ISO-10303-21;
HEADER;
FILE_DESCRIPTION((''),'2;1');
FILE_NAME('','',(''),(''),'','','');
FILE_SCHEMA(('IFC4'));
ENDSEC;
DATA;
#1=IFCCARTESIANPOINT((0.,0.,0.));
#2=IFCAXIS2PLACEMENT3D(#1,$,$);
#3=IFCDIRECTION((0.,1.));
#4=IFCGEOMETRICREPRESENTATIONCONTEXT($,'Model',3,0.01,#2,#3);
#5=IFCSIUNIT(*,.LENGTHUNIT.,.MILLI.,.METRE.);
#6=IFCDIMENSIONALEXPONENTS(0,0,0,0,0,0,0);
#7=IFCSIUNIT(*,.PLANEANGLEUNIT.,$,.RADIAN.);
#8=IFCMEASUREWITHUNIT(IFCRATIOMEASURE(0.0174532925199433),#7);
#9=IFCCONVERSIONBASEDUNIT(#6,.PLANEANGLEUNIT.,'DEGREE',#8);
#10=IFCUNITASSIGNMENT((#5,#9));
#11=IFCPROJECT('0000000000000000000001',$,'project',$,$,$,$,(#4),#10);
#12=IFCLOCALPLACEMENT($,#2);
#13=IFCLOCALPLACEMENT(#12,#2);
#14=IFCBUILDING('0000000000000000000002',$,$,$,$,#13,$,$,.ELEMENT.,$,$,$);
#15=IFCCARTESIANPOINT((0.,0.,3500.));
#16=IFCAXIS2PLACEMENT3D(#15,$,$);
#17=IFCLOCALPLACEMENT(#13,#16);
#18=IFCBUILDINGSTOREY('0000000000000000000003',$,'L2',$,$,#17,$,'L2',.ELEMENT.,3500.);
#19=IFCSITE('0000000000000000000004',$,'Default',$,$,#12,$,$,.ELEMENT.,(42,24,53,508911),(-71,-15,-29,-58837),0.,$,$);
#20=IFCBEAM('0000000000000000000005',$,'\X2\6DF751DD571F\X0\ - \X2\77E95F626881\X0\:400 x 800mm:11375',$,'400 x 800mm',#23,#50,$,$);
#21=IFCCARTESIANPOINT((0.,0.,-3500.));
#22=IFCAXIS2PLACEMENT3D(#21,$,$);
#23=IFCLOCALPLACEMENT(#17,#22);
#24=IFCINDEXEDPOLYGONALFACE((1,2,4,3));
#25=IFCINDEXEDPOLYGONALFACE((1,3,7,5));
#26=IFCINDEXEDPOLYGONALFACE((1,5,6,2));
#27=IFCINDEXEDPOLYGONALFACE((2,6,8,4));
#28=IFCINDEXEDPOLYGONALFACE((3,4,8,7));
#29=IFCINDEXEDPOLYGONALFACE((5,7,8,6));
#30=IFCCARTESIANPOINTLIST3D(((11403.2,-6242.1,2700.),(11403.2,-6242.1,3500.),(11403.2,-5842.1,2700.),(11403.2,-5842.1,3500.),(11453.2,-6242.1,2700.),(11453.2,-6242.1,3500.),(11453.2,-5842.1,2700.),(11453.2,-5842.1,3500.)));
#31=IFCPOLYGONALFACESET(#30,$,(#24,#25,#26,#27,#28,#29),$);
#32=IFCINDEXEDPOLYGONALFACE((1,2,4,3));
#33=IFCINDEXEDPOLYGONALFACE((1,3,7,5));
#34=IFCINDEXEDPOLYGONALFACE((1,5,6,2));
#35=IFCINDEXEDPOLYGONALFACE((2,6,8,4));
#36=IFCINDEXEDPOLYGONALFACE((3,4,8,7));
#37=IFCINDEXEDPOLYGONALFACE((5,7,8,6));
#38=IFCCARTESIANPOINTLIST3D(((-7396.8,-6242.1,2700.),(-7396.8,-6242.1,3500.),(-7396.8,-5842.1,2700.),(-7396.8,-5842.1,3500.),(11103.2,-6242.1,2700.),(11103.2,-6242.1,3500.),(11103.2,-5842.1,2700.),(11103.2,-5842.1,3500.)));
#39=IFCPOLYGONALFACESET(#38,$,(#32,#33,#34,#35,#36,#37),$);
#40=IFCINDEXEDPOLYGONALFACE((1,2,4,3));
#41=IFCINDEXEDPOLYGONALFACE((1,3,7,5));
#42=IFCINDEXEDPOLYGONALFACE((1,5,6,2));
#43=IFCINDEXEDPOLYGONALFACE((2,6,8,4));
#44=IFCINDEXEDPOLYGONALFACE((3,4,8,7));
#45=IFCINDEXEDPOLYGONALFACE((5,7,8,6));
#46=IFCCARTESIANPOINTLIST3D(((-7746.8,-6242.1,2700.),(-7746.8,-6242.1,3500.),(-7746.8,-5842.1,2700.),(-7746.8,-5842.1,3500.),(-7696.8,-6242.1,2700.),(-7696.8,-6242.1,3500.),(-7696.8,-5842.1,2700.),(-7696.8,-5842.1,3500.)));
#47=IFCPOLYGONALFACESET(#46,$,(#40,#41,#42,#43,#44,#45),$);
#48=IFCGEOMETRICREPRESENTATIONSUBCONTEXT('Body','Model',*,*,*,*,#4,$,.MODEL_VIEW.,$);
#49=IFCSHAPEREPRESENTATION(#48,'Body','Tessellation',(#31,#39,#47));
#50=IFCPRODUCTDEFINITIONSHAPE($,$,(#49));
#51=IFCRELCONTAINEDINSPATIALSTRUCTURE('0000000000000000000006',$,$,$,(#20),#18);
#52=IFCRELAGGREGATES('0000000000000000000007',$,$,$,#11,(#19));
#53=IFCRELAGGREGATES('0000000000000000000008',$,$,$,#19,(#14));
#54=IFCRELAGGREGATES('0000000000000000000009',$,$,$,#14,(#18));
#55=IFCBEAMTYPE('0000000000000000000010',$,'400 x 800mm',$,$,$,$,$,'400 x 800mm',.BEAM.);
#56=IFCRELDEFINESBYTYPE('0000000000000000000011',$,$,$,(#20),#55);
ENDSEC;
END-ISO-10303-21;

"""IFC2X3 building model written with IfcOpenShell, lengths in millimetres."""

from ifc_helpers import new_model, entity, si_unit, converted_unit, direction, frame, frame_2d, origin, place, context, subcontext, project, spatial, rectangle, extrude, source, transform, mapped, type_object, type_shapes, element, save


model = new_model("IFC2X3")

# Units and contexts
model_context = context("Model", 3, precision=0.01, world=origin(), true_north=direction((0.0, 1.0)))
body_context = subcontext(model_context, "Body", "Model", "MODEL_VIEW")
ifc_project = project(units=[si_unit("LENGTHUNIT", "METRE", prefix="MILLI"), converted_unit("PLANEANGLEUNIT", "DEGREE", entity("IfcRatioMeasure", 0.0174532925199433), si_unit("PLANEANGLEUNIT", "RADIAN"), dimensions=[0, 0, 0, 0, 0, 0, 0])], contexts=[model_context])

# Site, building, storey
site_placement = place(None, origin())
site = spatial("IfcSite", under=ifc_project, at=site_placement, Name="Default", CompositionType="ELEMENT", RefLatitude=(42, 24, 53, 508911), RefLongitude=(-71, -15, -29, -58837), RefElevation=0.0)
building_placement = place(site_placement, origin())
building = spatial("IfcBuilding", under=site, at=building_placement, CompositionType="ELEMENT")
storey_placement = place(building_placement, frame((0.0, 0.0, 3500.0)))
storey = spatial("IfcBuildingStorey", under=building, at=storey_placement, Name="L2", LongName="L2", CompositionType="ELEMENT", Elevation=3500.0)

# Beam
beam_type_1 = type_object("IfcBeamType", Name="400 x 800mm", ElementType="400 x 800mm", PredefinedType="BEAM")
shared_shape_1 = source(origin(), body_context, "Body", "SweptSolid", [
    extrude(rectangle(XDim=50.0, YDim=400.0, at=frame_2d((0.0, 0.0), x_axis=(1.0, 0.0))), frame((11428.2, -6042.1, 2700.0), z_axis=(0.0, 0.0, 1.0), x_axis=(-1.0, 0.0, 0.0)), (0.0, 0.0, 1.0), 800.0),
    extrude(rectangle(XDim=18500.0, YDim=400.0, at=frame_2d((0.0, -66.7), x_axis=(1.0, 0.0))), frame((1853.2, -5975.5, 2700.0)), (0.0, 0.0, 1.0), 800.0),
    extrude(rectangle(XDim=50.0, YDim=400.0, at=frame_2d((0.0, 0.0), x_axis=(1.0, 0.0))), frame((-7721.8, -6042.1, 2700.0)), (0.0, 0.0, 1.0), 800.0),
])
type_shapes(beam_type_1, [shared_shape_1])
beam_1_placement = place(storey_placement, frame((0.0, 0.0, -3500.0)))
element("IfcBeam", 1, at=beam_1_placement, inside=storey, type_object=beam_type_1, Name="混凝土 - 矩形梁:400 x 800mm:11375", ObjectType="400 x 800mm", context=body_context, shape_type="MappedRepresentation", body=[
    mapped(shared_shape_1, transform((0.0, 0.0, 0.0), scale=1.0)),
])

save(model, "model.ifc")
